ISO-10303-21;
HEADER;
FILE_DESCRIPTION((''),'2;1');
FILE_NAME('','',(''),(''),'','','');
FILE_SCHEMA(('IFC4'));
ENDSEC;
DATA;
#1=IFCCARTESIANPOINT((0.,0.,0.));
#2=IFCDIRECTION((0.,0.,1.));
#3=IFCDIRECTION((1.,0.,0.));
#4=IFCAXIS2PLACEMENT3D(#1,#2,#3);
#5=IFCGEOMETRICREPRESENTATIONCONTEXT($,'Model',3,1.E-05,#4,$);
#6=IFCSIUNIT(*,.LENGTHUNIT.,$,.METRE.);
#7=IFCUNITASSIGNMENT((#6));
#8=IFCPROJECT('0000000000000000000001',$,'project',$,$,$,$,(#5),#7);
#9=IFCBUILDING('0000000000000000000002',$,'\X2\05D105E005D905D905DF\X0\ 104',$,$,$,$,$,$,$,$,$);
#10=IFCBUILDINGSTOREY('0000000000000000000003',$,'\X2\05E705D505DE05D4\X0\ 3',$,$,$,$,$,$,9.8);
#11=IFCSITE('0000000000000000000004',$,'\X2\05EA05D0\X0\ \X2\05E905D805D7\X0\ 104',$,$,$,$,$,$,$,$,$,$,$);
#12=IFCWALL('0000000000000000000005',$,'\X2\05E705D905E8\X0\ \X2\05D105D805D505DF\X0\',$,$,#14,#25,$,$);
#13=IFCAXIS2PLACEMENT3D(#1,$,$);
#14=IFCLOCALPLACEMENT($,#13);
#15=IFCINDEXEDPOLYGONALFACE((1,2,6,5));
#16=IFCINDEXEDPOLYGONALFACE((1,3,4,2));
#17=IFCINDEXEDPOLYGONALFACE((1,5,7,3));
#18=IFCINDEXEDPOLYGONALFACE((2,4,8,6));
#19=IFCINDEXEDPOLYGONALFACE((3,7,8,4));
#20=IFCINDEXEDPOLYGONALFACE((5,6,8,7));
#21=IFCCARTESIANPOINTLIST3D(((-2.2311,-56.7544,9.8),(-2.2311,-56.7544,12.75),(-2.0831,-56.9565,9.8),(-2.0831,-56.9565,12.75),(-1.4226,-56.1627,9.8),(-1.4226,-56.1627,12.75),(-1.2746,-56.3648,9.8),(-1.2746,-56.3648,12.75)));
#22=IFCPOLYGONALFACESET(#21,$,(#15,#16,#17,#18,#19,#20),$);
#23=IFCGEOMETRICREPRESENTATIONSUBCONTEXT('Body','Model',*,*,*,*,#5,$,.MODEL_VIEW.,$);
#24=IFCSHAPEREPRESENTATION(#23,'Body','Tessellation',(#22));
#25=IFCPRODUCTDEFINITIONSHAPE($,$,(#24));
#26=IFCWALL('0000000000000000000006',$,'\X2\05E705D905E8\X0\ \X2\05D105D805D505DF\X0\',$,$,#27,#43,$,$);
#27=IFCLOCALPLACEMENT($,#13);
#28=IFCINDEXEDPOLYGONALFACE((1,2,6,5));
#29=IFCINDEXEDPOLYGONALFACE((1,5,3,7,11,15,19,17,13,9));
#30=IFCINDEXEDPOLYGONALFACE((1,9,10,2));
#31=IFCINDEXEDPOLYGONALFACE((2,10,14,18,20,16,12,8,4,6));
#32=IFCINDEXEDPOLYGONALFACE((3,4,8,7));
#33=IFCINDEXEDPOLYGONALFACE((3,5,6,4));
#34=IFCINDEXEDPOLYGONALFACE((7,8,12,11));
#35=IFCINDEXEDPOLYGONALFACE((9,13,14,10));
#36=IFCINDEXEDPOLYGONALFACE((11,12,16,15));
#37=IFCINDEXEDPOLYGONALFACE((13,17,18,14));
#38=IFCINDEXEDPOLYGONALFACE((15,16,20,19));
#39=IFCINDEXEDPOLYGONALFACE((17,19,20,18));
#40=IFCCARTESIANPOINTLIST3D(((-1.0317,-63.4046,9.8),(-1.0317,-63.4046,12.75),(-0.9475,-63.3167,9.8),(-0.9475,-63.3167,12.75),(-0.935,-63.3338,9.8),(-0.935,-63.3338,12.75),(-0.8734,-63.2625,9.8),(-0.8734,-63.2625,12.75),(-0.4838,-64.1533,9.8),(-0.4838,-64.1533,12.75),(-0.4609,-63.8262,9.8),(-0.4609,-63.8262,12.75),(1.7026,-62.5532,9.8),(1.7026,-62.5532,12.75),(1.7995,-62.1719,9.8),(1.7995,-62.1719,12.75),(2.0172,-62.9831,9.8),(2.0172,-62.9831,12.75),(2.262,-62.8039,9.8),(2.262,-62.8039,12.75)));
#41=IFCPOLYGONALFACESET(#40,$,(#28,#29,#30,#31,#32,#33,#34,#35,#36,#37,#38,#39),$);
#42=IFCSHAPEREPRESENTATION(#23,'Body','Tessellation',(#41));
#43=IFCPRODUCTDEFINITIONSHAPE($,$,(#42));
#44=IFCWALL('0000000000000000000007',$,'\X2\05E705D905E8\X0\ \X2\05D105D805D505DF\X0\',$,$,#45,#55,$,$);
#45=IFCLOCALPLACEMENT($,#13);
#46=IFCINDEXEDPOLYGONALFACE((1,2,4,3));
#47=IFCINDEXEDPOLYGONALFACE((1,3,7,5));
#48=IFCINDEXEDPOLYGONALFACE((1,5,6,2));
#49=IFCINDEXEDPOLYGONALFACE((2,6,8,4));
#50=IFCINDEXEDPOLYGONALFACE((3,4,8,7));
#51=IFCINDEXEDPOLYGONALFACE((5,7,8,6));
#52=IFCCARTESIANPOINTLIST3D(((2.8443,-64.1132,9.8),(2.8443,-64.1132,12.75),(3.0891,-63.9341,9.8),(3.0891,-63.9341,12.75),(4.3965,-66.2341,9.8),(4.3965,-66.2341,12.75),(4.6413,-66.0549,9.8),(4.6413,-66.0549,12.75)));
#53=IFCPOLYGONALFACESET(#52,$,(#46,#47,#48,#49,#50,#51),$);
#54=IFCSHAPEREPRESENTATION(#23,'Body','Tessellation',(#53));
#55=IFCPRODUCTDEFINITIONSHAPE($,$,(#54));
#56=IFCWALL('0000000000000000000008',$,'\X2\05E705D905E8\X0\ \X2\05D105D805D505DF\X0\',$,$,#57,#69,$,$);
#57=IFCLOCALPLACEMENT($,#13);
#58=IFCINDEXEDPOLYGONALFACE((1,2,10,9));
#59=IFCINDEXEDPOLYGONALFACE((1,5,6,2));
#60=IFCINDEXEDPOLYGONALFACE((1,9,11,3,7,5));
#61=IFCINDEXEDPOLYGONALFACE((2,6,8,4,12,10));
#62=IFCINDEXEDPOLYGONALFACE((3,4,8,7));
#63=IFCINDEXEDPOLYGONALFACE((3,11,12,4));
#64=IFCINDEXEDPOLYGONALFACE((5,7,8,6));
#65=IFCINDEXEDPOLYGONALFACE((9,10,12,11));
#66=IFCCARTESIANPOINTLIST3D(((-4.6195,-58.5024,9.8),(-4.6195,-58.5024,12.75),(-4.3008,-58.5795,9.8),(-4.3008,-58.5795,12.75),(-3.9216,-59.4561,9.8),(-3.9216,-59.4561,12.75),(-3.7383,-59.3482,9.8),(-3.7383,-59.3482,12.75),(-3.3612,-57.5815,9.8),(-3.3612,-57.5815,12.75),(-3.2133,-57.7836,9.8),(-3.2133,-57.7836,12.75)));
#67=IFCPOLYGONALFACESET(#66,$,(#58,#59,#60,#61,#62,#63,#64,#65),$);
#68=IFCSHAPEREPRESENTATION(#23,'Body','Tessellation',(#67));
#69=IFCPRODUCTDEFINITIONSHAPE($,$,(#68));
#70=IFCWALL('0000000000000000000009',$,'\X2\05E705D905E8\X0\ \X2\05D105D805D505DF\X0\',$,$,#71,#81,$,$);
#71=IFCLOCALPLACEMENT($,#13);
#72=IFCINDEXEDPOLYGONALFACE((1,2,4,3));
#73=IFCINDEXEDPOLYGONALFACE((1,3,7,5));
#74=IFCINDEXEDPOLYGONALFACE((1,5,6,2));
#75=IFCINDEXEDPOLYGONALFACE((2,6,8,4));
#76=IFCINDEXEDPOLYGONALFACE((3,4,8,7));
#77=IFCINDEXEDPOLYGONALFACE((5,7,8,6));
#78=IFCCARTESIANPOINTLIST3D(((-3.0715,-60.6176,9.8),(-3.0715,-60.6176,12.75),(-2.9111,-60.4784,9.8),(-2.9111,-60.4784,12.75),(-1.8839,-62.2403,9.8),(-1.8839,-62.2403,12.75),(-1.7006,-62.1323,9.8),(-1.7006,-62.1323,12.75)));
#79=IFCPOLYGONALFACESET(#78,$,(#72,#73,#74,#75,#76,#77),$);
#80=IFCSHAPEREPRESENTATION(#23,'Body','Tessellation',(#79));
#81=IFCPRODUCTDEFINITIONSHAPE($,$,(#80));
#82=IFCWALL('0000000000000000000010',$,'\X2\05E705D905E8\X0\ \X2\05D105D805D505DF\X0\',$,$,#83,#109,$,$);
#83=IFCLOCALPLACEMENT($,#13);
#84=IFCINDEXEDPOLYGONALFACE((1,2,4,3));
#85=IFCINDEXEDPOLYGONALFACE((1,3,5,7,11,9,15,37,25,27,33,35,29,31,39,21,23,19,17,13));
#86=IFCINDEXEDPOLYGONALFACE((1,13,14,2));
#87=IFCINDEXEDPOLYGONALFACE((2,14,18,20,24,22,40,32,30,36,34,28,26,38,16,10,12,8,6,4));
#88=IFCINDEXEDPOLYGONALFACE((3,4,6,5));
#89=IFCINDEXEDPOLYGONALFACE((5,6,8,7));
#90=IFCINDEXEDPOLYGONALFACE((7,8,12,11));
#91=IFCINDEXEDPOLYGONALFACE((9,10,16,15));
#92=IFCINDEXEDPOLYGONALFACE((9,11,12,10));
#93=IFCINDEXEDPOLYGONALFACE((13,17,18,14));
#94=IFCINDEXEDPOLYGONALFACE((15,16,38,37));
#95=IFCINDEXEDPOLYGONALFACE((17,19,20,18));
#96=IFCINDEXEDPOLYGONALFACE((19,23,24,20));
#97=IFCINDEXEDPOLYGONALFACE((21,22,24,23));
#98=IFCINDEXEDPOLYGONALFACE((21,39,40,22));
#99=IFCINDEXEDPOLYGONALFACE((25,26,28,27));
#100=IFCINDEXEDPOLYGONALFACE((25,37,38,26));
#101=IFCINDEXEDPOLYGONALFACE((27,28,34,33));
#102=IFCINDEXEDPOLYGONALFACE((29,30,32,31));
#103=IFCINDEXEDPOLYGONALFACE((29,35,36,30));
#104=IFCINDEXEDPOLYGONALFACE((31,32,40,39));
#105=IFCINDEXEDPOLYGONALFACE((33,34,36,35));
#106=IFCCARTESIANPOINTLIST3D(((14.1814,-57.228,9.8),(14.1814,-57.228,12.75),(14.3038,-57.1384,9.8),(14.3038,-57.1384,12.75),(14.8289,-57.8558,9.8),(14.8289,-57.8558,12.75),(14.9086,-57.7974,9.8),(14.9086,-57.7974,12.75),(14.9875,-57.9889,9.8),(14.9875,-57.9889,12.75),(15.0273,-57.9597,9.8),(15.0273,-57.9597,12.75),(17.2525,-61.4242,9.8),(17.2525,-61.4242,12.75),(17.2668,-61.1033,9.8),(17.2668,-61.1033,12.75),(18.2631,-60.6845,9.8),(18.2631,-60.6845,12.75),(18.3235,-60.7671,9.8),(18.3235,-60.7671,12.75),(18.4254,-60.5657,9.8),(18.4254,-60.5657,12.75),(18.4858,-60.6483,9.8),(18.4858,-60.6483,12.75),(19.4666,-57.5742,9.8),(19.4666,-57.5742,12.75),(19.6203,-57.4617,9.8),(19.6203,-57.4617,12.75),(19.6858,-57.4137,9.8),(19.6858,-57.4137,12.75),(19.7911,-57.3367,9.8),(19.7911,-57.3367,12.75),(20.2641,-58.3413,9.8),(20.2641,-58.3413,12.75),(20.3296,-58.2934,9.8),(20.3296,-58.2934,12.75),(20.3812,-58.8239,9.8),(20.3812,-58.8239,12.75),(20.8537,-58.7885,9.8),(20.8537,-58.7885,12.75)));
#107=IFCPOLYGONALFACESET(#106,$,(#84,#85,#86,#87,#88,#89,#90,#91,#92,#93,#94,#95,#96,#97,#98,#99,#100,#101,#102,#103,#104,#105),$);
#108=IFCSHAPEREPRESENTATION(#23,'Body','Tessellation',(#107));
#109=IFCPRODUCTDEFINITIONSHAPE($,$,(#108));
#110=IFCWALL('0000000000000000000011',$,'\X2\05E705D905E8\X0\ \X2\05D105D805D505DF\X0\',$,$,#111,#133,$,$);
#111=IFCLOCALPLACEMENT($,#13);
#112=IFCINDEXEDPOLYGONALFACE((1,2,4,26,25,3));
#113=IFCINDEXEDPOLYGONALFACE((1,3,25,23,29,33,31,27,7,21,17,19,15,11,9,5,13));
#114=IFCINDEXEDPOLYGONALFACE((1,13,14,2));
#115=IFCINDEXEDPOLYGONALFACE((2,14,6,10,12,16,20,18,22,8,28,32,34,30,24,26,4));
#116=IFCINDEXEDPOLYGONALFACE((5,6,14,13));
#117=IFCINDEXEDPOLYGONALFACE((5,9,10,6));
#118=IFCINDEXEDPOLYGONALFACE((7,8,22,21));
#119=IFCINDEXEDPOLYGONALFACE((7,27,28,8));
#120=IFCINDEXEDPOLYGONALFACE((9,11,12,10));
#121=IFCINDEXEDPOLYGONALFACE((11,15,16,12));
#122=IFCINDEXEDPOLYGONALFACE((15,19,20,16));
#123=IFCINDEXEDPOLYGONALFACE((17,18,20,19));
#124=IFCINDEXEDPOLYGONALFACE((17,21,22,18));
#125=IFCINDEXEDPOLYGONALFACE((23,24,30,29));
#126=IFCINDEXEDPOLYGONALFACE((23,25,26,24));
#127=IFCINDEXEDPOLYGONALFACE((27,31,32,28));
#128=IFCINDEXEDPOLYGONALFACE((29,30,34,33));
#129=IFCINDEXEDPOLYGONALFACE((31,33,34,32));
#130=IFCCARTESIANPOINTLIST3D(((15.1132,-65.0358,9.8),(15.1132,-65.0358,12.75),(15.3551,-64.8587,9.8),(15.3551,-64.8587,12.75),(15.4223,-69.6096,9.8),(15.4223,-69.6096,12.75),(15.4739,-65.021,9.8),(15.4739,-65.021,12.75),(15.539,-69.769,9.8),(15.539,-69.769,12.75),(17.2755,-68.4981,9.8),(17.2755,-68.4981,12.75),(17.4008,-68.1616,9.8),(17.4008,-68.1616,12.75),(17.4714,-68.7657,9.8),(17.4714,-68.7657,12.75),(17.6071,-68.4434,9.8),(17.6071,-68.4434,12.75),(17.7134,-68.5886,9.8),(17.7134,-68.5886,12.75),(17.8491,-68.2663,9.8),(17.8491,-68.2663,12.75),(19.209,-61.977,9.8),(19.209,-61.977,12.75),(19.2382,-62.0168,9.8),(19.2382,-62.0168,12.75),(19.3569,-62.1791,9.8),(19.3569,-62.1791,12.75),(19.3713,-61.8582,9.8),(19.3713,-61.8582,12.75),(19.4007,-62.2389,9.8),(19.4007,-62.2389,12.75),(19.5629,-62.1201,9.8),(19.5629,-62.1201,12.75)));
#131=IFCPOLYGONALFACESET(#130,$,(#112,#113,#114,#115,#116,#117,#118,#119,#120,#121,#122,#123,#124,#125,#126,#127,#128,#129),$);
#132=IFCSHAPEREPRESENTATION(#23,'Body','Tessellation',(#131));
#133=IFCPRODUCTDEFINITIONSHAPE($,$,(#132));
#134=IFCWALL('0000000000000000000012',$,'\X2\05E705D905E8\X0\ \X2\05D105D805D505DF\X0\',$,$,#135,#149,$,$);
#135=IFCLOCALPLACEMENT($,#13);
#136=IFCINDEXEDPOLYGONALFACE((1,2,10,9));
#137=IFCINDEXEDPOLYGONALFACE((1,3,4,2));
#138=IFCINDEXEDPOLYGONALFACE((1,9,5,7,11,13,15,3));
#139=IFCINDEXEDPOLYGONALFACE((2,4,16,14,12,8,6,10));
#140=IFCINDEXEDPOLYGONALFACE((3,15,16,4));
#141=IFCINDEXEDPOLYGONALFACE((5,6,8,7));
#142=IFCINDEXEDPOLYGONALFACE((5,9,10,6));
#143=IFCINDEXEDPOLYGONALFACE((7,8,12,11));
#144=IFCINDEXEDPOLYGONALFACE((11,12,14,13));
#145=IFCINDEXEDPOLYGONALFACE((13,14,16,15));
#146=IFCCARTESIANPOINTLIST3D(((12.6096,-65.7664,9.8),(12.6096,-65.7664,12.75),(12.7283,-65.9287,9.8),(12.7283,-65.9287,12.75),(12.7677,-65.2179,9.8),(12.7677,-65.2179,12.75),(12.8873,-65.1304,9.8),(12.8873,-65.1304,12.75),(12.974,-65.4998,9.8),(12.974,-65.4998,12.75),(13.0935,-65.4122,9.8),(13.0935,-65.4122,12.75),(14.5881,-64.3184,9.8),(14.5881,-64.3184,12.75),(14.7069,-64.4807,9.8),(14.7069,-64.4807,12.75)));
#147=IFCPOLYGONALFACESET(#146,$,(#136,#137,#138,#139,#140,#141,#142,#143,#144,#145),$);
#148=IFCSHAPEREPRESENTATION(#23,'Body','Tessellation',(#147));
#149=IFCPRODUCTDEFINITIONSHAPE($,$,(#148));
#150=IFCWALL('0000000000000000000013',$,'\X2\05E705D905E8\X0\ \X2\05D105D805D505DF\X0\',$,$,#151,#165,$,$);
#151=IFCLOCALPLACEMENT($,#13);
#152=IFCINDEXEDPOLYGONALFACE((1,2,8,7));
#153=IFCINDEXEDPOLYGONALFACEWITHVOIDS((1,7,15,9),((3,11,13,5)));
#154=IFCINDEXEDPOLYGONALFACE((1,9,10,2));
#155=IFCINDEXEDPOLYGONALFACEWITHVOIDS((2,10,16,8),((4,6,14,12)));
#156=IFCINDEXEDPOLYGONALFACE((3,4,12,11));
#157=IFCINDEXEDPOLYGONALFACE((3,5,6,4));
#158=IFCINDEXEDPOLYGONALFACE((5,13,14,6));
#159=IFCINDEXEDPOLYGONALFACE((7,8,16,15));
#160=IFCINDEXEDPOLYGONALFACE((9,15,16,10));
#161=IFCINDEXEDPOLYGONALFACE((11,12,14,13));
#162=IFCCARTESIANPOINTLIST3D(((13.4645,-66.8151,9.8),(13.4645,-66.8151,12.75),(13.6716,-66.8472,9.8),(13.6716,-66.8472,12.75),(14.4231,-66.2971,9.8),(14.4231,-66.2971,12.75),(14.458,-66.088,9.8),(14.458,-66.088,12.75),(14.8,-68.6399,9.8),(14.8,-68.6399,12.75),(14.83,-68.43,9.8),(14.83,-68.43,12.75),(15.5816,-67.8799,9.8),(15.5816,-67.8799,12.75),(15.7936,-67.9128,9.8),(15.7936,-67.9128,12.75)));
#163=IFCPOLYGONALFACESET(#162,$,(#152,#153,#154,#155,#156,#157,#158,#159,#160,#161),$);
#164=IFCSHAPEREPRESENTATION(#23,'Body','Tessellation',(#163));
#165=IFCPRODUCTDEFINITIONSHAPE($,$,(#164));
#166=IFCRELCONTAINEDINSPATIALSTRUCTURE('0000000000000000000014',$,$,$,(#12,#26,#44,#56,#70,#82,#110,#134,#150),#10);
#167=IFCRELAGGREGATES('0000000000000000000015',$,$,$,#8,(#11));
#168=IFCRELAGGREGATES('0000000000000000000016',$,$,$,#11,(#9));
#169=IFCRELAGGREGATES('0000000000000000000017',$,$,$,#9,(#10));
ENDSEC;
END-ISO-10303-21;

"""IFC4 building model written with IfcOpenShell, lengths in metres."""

from ifc_helpers import new_model, si_unit, frame, origin_with_axes, context, subcontext, project, spatial, polyline, outline, extrude, element, save


model = new_model("IFC4")

# Units and contexts
model_context = context("Model", 3, precision=1e-05, world=origin_with_axes())
body_context = subcontext(model_context, "Body", "Model", "MODEL_VIEW")
ifc_project = project(units=[si_unit("LENGTHUNIT", "METRE")], contexts=[model_context])

# Site, building, storey
site = spatial("IfcSite", under=ifc_project, Name="תא שטח 104")
building = spatial("IfcBuilding", under=site, Name="בניין 104")
storey = spatial("IfcBuildingStorey", under=building, Name="קומה 3", Elevation=9.8)

# Walls
element("IfcWall", 1, inside=storey, Name="קיר בטון", context=body_context, shape_type="SweptSolid", body=[
    extrude(outline(polyline([(-1.4226, -56.1627), (-2.2311, -56.7544), (-2.0831, -56.9565), (-1.2746, -56.3648), (-1.4226, -56.1627)])), frame((0.0, 0.0, 9.8)), (0.0, 0.0, 1.0), 2.95),
])
element("IfcWall", 2, inside=storey, Name="קיר בטון", context=body_context, shape_type="SweptSolid", body=[
    extrude(outline(polyline([(-0.9475, -63.3167), (-0.935, -63.3338), (-1.0317, -63.4046), (-0.4838, -64.1533), (1.7026, -62.5532), (2.0172, -62.9831), (2.262, -62.8039), (1.7995, -62.1719), (-0.4609, -63.8262), (-0.8734, -63.2625), (-0.9475, -63.3167)])), frame((0.0, 0.0, 9.8)), (0.0, 0.0, 1.0), 2.95),
])
element("IfcWall", 3, inside=storey, Name="קיר בטון", context=body_context, shape_type="SweptSolid", body=[
    extrude(outline(polyline([(4.6413, -66.0549), (3.0891, -63.9341), (2.8443, -64.1132), (4.3965, -66.2341), (4.6413, -66.0549)])), frame((0.0, 0.0, 9.8)), (0.0, 0.0, 1.0), 2.95),
])
element("IfcWall", 4, inside=storey, Name="קיר בטון", context=body_context, shape_type="SweptSolid", body=[
    extrude(outline(polyline([(-4.6195, -58.5024), (-3.9216, -59.4561), (-3.7383, -59.3482), (-4.3008, -58.5795), (-3.2133, -57.7836), (-3.3612, -57.5815), (-4.6195, -58.5024)])), frame((0.0, 0.0, 9.8)), (0.0, 0.0, 1.0), 2.95),
])
element("IfcWall", 5, inside=storey, Name="קיר בטון", context=body_context, shape_type="SweptSolid", body=[
    extrude(outline(polyline([(-3.0715, -60.6176), (-1.8839, -62.2403), (-1.7006, -62.1323), (-2.9111, -60.4784), (-3.0715, -60.6176)])), frame((0.0, 0.0, 9.8)), (0.0, 0.0, 1.0), 2.95),
])
element("IfcWall", 6, inside=storey, Name="קיר בטון", context=body_context, shape_type="SweptSolid", body=[
    extrude(outline(polyline([(19.6203, -57.4617), (19.4666, -57.5742), (20.3812, -58.8239), (17.2668, -61.1033), (14.9875, -57.9889), (15.0273, -57.9597), (14.9086, -57.7974), (14.8289, -57.8558), (14.3038, -57.1384), (14.1814, -57.228), (17.2525, -61.4242), (18.2631, -60.6845), (18.3235, -60.7671), (18.4858, -60.6483), (18.4254, -60.5657), (20.8537, -58.7885), (19.7911, -57.3367), (19.6858, -57.4137), (20.3296, -58.2934), (20.2641, -58.3413), (19.6203, -57.4617)])), frame((0.0, 0.0, 9.8)), (0.0, 0.0, 1.0), 2.95),
])
element("IfcWall", 7, inside=storey, Name="קיר בטון", context=body_context, shape_type="SweptSolid", body=[
    extrude(outline(polyline([(19.3569, -62.1791), (19.4007, -62.2389), (19.5629, -62.1201), (19.3713, -61.8582), (19.209, -61.977), (19.2382, -62.0168), (15.3551, -64.8587), (15.1132, -65.0358), (15.1132, -65.0358), (17.4008, -68.1616), (15.4223, -69.6096), (15.539, -69.769), (17.2755, -68.4981), (17.4714, -68.7657), (17.7134, -68.5886), (17.6071, -68.4434), (17.8491, -68.2663), (15.4739, -65.021), (19.3569, -62.1791)])), frame((0.0, 0.0, 9.8)), (0.0, 0.0, 1.0), 2.95),
])
element("IfcWall", 8, inside=storey, Name="קיר בטון", context=body_context, shape_type="SweptSolid", body=[
    extrude(outline(polyline([(12.7677, -65.2179), (12.974, -65.4998), (12.6096, -65.7664), (12.7283, -65.9287), (14.7069, -64.4807), (14.5881, -64.3184), (13.0935, -65.4122), (12.8873, -65.1304), (12.7677, -65.2179)])), frame((0.0, 0.0, 9.8)), (0.0, 0.0, 1.0), 2.95),
])
element("IfcWall", 9, inside=storey, Name="קיר בטון", context=body_context, shape_type="SweptSolid", body=[
    extrude(outline(polyline([(13.4645, -66.8151), (14.8, -68.6399), (15.7936, -67.9128), (14.458, -66.088), (13.4645, -66.8151)]), holes=[polyline([(13.6716, -66.8472), (14.4231, -66.2971), (15.5816, -67.8799), (14.83, -68.43), (13.6716, -66.8472)])]), frame((0.0, 0.0, 9.8)), (0.0, 0.0, 1.0), 2.95),
])

save(model, "model.ifc")
